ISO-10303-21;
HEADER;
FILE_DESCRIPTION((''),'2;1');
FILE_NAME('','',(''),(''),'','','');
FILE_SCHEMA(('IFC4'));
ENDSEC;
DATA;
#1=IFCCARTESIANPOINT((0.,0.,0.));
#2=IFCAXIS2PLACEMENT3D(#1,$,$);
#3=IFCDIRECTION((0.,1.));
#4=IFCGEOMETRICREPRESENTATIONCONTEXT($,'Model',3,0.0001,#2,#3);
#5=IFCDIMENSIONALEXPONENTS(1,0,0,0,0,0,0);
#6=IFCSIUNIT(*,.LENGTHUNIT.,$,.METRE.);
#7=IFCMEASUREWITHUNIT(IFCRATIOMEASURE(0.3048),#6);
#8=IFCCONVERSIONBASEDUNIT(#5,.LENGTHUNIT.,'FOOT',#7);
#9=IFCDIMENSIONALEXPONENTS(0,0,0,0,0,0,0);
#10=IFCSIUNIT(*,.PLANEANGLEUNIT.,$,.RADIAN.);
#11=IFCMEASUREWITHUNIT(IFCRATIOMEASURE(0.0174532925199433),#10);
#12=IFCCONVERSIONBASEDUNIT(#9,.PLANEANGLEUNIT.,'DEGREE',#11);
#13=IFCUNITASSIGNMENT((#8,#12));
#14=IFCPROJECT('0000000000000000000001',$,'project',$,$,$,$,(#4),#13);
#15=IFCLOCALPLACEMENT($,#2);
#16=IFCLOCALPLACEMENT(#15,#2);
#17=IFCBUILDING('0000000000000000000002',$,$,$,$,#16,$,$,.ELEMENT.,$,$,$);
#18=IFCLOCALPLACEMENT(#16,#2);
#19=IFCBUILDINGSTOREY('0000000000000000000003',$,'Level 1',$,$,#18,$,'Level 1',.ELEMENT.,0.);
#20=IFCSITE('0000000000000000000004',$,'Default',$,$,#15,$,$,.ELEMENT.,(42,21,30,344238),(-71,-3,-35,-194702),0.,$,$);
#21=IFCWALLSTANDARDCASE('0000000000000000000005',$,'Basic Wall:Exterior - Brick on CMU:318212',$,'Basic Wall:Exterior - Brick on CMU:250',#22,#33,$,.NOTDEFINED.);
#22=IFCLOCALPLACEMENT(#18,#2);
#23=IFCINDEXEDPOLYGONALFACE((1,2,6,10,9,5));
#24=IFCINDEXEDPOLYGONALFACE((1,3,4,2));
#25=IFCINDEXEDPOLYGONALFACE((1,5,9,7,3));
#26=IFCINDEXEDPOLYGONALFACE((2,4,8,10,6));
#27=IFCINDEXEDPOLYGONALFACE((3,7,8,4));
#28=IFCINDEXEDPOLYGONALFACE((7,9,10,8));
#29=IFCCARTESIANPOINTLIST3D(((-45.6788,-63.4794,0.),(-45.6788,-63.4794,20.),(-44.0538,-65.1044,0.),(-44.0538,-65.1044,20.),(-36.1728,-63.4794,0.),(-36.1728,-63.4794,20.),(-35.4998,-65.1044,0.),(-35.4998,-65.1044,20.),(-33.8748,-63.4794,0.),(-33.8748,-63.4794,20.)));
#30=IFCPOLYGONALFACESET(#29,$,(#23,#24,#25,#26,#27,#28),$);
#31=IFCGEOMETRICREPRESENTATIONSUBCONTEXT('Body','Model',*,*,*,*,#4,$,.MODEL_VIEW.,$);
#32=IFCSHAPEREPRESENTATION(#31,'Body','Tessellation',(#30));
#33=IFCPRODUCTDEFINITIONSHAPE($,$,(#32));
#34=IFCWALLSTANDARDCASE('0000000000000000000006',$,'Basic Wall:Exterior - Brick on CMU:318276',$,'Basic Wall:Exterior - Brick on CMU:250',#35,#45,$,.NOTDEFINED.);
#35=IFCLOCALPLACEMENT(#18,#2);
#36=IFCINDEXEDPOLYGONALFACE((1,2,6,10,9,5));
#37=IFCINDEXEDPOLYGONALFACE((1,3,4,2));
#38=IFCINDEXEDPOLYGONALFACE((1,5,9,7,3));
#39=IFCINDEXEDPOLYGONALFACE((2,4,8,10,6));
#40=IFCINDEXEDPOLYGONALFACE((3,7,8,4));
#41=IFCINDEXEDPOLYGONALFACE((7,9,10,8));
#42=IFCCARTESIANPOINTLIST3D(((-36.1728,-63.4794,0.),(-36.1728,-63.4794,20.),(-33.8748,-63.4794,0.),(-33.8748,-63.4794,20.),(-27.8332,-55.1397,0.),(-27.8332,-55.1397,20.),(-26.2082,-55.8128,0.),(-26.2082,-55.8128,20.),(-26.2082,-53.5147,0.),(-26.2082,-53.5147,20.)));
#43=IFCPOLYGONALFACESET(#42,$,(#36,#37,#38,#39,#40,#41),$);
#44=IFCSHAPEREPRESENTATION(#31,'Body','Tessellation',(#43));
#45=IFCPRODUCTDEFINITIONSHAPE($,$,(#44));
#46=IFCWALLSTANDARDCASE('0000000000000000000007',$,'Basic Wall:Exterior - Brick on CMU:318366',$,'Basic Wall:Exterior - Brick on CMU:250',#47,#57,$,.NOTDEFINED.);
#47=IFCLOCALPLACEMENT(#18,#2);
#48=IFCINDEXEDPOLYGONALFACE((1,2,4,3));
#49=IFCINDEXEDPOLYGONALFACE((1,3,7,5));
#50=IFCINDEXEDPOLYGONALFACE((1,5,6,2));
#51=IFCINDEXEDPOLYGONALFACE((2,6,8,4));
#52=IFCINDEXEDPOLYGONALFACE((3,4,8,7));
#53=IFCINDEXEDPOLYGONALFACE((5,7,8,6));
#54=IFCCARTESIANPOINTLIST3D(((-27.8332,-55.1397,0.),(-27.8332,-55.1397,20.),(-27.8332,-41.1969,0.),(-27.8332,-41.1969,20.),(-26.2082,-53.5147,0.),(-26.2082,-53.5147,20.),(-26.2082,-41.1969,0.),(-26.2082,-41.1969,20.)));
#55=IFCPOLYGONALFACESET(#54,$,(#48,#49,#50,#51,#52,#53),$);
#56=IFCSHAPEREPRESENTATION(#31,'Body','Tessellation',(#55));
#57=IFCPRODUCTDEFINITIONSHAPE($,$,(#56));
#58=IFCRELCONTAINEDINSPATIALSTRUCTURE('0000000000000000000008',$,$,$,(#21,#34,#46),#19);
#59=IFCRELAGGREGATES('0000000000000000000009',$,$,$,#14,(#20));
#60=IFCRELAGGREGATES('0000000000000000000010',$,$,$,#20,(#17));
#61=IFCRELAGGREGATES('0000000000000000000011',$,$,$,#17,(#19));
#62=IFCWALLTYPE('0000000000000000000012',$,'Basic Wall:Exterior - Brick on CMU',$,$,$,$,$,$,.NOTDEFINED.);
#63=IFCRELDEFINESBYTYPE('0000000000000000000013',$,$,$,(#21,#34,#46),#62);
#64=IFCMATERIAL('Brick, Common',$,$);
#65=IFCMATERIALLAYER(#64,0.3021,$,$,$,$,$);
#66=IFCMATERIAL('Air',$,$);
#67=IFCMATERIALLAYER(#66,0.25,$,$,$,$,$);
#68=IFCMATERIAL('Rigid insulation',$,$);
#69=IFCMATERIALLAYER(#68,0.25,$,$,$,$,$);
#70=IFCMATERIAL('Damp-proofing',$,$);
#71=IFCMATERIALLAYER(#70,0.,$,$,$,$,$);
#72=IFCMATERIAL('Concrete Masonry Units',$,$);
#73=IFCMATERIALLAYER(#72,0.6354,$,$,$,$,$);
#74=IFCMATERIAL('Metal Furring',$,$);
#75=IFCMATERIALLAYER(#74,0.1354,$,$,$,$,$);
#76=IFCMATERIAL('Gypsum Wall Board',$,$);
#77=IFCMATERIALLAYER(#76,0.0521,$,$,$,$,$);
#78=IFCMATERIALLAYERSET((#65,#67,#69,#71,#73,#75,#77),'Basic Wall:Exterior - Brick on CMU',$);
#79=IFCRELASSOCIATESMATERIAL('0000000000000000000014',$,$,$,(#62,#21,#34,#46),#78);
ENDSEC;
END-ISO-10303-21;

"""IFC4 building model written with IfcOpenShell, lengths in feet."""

from ifc_helpers import new_model, entity, si_unit, converted_unit, direction, frame, origin, place, context, subcontext, project, spatial, polyline, outline, extrude, material, layer, layer_set, layer_usage, type_object, element, save


model = new_model("IFC4")

# Units and contexts
model_context = context("Model", 3, precision=0.0001, world=origin(), true_north=direction((0.0, 1.0)))
body_context = subcontext(model_context, "Body", "Model", "MODEL_VIEW")
ifc_project = project(units=[converted_unit("LENGTHUNIT", "FOOT", entity("IfcRatioMeasure", 0.3048), si_unit("LENGTHUNIT", "METRE"), dimensions=[1, 0, 0, 0, 0, 0, 0]), converted_unit("PLANEANGLEUNIT", "DEGREE", entity("IfcRatioMeasure", 0.0174532925199433), si_unit("PLANEANGLEUNIT", "RADIAN"), dimensions=[0, 0, 0, 0, 0, 0, 0])], contexts=[model_context])

# Site, building, storey
site_placement = place(None, origin())
site = spatial("IfcSite", under=ifc_project, at=site_placement, Name="Default", CompositionType="ELEMENT", RefLatitude=(42, 21, 30, 344238), RefLongitude=(-71, -3, -35, -194702), RefElevation=0.0)
building_placement = place(site_placement, origin())
building = spatial("IfcBuilding", under=site, at=building_placement, CompositionType="ELEMENT")
storey_placement = place(building_placement, origin())
storey = spatial("IfcBuildingStorey", under=building, at=storey_placement, Name="Level 1", LongName="Level 1", CompositionType="ELEMENT", Elevation=0.0)

# Walls
ifc_material_1 = material(Name="Brick, Common")
ifc_layer_1 = layer(ifc_material_1, 0.3021)
ifc_material_2 = material(Name="Air")
ifc_layer_2 = layer(ifc_material_2, 0.25)
ifc_material_3 = material(Name="Rigid insulation")
ifc_layer_3 = layer(ifc_material_3, 0.25)
ifc_material_4 = material(Name="Damp-proofing")
ifc_layer_4 = layer(ifc_material_4, 0.0)
ifc_material_5 = material(Name="Concrete Masonry Units")
ifc_layer_5 = layer(ifc_material_5, 0.6354)
ifc_material_6 = material(Name="Metal Furring")
ifc_layer_6 = layer(ifc_material_6, 0.1354)
ifc_material_7 = material(Name="Gypsum Wall Board")
ifc_layer_7 = layer(ifc_material_7, 0.0521)
ifc_layer_set = layer_set([ifc_layer_1, ifc_layer_2, ifc_layer_3, ifc_layer_4, ifc_layer_5, ifc_layer_6, ifc_layer_7], Name="Basic Wall:Exterior - Brick on CMU")
ifc_layer_usage_1 = layer_usage(ifc_layer_set, "AXIS2", "NEGATIVE", 0.8125)
wall_type = type_object("IfcWallType", Name="Basic Wall:Exterior - Brick on CMU", PredefinedType="NOTDEFINED", material=ifc_layer_set)
wall_1_placement = place(storey_placement, frame((-45.6788, -64.2919, 0.0)))
element("IfcWallStandardCase", 1, at=wall_1_placement, inside=storey, type_object=wall_type, material=ifc_layer_usage_1, Name="Basic Wall:Exterior - Brick on CMU:318212", ObjectType="Basic Wall:Exterior - Brick on CMU:250", PredefinedType="NOTDEFINED", context=body_context, shape_type="SweptSolid", body=[
    extrude(outline(polyline([(10.1791, -0.8125), (11.8041, 0.8125), (9.506, 0.8125), (0.0, 0.8125), (1.625, -0.8125), (10.1791, -0.8125)])), origin(), (0.0, 0.0, 1.0), 20.0),
])
ifc_layer_usage_2 = layer_usage(ifc_layer_set, "AXIS2", "NEGATIVE", 0.8125)
wall_2_placement = place(storey_placement, frame((-35.5983, -64.0539, 0.0), z_axis=(0.0, 0.0, 1.0), x_axis=(0.707107, 0.707107, 0.0)))
element("IfcWallStandardCase", 2, at=wall_2_placement, inside=storey, type_object=wall_type, material=ifc_layer_usage_2, Name="Basic Wall:Exterior - Brick on CMU:318276", ObjectType="Basic Wall:Exterior - Brick on CMU:250", PredefinedType="NOTDEFINED", context=body_context, shape_type="SweptSolid", body=[
    extrude(outline(polyline([(12.4672, -0.8125), (14.0922, 0.8125), (11.7941, 0.8125), (0.0, 0.8125), (1.625, -0.8125), (12.4672, -0.8125)])), origin(), (0.0, 0.0, 1.0), 20.0),
])
ifc_layer_usage_3 = layer_usage(ifc_layer_set, "AXIS2", "NEGATIVE", 0.8125)
wall_3_placement = place(storey_placement, frame((-27.0207, -55.1397, 0.0), z_axis=(0.0, 0.0, 1.0), x_axis=(0.0, 1.0, 0.0)))
element("IfcWallStandardCase", 3, at=wall_3_placement, inside=storey, type_object=wall_type, material=ifc_layer_usage_3, Name="Basic Wall:Exterior - Brick on CMU:318366", ObjectType="Basic Wall:Exterior - Brick on CMU:250", PredefinedType="NOTDEFINED", context=body_context, shape_type="SweptSolid", body=[
    extrude(outline(polyline([(13.9428, -0.8125), (13.9428, 0.8125), (0.0, 0.8125), (1.625, -0.8125), (13.9428, -0.8125)])), origin(), (0.0, 0.0, 1.0), 20.0),
])

save(model, "model.ifc")
